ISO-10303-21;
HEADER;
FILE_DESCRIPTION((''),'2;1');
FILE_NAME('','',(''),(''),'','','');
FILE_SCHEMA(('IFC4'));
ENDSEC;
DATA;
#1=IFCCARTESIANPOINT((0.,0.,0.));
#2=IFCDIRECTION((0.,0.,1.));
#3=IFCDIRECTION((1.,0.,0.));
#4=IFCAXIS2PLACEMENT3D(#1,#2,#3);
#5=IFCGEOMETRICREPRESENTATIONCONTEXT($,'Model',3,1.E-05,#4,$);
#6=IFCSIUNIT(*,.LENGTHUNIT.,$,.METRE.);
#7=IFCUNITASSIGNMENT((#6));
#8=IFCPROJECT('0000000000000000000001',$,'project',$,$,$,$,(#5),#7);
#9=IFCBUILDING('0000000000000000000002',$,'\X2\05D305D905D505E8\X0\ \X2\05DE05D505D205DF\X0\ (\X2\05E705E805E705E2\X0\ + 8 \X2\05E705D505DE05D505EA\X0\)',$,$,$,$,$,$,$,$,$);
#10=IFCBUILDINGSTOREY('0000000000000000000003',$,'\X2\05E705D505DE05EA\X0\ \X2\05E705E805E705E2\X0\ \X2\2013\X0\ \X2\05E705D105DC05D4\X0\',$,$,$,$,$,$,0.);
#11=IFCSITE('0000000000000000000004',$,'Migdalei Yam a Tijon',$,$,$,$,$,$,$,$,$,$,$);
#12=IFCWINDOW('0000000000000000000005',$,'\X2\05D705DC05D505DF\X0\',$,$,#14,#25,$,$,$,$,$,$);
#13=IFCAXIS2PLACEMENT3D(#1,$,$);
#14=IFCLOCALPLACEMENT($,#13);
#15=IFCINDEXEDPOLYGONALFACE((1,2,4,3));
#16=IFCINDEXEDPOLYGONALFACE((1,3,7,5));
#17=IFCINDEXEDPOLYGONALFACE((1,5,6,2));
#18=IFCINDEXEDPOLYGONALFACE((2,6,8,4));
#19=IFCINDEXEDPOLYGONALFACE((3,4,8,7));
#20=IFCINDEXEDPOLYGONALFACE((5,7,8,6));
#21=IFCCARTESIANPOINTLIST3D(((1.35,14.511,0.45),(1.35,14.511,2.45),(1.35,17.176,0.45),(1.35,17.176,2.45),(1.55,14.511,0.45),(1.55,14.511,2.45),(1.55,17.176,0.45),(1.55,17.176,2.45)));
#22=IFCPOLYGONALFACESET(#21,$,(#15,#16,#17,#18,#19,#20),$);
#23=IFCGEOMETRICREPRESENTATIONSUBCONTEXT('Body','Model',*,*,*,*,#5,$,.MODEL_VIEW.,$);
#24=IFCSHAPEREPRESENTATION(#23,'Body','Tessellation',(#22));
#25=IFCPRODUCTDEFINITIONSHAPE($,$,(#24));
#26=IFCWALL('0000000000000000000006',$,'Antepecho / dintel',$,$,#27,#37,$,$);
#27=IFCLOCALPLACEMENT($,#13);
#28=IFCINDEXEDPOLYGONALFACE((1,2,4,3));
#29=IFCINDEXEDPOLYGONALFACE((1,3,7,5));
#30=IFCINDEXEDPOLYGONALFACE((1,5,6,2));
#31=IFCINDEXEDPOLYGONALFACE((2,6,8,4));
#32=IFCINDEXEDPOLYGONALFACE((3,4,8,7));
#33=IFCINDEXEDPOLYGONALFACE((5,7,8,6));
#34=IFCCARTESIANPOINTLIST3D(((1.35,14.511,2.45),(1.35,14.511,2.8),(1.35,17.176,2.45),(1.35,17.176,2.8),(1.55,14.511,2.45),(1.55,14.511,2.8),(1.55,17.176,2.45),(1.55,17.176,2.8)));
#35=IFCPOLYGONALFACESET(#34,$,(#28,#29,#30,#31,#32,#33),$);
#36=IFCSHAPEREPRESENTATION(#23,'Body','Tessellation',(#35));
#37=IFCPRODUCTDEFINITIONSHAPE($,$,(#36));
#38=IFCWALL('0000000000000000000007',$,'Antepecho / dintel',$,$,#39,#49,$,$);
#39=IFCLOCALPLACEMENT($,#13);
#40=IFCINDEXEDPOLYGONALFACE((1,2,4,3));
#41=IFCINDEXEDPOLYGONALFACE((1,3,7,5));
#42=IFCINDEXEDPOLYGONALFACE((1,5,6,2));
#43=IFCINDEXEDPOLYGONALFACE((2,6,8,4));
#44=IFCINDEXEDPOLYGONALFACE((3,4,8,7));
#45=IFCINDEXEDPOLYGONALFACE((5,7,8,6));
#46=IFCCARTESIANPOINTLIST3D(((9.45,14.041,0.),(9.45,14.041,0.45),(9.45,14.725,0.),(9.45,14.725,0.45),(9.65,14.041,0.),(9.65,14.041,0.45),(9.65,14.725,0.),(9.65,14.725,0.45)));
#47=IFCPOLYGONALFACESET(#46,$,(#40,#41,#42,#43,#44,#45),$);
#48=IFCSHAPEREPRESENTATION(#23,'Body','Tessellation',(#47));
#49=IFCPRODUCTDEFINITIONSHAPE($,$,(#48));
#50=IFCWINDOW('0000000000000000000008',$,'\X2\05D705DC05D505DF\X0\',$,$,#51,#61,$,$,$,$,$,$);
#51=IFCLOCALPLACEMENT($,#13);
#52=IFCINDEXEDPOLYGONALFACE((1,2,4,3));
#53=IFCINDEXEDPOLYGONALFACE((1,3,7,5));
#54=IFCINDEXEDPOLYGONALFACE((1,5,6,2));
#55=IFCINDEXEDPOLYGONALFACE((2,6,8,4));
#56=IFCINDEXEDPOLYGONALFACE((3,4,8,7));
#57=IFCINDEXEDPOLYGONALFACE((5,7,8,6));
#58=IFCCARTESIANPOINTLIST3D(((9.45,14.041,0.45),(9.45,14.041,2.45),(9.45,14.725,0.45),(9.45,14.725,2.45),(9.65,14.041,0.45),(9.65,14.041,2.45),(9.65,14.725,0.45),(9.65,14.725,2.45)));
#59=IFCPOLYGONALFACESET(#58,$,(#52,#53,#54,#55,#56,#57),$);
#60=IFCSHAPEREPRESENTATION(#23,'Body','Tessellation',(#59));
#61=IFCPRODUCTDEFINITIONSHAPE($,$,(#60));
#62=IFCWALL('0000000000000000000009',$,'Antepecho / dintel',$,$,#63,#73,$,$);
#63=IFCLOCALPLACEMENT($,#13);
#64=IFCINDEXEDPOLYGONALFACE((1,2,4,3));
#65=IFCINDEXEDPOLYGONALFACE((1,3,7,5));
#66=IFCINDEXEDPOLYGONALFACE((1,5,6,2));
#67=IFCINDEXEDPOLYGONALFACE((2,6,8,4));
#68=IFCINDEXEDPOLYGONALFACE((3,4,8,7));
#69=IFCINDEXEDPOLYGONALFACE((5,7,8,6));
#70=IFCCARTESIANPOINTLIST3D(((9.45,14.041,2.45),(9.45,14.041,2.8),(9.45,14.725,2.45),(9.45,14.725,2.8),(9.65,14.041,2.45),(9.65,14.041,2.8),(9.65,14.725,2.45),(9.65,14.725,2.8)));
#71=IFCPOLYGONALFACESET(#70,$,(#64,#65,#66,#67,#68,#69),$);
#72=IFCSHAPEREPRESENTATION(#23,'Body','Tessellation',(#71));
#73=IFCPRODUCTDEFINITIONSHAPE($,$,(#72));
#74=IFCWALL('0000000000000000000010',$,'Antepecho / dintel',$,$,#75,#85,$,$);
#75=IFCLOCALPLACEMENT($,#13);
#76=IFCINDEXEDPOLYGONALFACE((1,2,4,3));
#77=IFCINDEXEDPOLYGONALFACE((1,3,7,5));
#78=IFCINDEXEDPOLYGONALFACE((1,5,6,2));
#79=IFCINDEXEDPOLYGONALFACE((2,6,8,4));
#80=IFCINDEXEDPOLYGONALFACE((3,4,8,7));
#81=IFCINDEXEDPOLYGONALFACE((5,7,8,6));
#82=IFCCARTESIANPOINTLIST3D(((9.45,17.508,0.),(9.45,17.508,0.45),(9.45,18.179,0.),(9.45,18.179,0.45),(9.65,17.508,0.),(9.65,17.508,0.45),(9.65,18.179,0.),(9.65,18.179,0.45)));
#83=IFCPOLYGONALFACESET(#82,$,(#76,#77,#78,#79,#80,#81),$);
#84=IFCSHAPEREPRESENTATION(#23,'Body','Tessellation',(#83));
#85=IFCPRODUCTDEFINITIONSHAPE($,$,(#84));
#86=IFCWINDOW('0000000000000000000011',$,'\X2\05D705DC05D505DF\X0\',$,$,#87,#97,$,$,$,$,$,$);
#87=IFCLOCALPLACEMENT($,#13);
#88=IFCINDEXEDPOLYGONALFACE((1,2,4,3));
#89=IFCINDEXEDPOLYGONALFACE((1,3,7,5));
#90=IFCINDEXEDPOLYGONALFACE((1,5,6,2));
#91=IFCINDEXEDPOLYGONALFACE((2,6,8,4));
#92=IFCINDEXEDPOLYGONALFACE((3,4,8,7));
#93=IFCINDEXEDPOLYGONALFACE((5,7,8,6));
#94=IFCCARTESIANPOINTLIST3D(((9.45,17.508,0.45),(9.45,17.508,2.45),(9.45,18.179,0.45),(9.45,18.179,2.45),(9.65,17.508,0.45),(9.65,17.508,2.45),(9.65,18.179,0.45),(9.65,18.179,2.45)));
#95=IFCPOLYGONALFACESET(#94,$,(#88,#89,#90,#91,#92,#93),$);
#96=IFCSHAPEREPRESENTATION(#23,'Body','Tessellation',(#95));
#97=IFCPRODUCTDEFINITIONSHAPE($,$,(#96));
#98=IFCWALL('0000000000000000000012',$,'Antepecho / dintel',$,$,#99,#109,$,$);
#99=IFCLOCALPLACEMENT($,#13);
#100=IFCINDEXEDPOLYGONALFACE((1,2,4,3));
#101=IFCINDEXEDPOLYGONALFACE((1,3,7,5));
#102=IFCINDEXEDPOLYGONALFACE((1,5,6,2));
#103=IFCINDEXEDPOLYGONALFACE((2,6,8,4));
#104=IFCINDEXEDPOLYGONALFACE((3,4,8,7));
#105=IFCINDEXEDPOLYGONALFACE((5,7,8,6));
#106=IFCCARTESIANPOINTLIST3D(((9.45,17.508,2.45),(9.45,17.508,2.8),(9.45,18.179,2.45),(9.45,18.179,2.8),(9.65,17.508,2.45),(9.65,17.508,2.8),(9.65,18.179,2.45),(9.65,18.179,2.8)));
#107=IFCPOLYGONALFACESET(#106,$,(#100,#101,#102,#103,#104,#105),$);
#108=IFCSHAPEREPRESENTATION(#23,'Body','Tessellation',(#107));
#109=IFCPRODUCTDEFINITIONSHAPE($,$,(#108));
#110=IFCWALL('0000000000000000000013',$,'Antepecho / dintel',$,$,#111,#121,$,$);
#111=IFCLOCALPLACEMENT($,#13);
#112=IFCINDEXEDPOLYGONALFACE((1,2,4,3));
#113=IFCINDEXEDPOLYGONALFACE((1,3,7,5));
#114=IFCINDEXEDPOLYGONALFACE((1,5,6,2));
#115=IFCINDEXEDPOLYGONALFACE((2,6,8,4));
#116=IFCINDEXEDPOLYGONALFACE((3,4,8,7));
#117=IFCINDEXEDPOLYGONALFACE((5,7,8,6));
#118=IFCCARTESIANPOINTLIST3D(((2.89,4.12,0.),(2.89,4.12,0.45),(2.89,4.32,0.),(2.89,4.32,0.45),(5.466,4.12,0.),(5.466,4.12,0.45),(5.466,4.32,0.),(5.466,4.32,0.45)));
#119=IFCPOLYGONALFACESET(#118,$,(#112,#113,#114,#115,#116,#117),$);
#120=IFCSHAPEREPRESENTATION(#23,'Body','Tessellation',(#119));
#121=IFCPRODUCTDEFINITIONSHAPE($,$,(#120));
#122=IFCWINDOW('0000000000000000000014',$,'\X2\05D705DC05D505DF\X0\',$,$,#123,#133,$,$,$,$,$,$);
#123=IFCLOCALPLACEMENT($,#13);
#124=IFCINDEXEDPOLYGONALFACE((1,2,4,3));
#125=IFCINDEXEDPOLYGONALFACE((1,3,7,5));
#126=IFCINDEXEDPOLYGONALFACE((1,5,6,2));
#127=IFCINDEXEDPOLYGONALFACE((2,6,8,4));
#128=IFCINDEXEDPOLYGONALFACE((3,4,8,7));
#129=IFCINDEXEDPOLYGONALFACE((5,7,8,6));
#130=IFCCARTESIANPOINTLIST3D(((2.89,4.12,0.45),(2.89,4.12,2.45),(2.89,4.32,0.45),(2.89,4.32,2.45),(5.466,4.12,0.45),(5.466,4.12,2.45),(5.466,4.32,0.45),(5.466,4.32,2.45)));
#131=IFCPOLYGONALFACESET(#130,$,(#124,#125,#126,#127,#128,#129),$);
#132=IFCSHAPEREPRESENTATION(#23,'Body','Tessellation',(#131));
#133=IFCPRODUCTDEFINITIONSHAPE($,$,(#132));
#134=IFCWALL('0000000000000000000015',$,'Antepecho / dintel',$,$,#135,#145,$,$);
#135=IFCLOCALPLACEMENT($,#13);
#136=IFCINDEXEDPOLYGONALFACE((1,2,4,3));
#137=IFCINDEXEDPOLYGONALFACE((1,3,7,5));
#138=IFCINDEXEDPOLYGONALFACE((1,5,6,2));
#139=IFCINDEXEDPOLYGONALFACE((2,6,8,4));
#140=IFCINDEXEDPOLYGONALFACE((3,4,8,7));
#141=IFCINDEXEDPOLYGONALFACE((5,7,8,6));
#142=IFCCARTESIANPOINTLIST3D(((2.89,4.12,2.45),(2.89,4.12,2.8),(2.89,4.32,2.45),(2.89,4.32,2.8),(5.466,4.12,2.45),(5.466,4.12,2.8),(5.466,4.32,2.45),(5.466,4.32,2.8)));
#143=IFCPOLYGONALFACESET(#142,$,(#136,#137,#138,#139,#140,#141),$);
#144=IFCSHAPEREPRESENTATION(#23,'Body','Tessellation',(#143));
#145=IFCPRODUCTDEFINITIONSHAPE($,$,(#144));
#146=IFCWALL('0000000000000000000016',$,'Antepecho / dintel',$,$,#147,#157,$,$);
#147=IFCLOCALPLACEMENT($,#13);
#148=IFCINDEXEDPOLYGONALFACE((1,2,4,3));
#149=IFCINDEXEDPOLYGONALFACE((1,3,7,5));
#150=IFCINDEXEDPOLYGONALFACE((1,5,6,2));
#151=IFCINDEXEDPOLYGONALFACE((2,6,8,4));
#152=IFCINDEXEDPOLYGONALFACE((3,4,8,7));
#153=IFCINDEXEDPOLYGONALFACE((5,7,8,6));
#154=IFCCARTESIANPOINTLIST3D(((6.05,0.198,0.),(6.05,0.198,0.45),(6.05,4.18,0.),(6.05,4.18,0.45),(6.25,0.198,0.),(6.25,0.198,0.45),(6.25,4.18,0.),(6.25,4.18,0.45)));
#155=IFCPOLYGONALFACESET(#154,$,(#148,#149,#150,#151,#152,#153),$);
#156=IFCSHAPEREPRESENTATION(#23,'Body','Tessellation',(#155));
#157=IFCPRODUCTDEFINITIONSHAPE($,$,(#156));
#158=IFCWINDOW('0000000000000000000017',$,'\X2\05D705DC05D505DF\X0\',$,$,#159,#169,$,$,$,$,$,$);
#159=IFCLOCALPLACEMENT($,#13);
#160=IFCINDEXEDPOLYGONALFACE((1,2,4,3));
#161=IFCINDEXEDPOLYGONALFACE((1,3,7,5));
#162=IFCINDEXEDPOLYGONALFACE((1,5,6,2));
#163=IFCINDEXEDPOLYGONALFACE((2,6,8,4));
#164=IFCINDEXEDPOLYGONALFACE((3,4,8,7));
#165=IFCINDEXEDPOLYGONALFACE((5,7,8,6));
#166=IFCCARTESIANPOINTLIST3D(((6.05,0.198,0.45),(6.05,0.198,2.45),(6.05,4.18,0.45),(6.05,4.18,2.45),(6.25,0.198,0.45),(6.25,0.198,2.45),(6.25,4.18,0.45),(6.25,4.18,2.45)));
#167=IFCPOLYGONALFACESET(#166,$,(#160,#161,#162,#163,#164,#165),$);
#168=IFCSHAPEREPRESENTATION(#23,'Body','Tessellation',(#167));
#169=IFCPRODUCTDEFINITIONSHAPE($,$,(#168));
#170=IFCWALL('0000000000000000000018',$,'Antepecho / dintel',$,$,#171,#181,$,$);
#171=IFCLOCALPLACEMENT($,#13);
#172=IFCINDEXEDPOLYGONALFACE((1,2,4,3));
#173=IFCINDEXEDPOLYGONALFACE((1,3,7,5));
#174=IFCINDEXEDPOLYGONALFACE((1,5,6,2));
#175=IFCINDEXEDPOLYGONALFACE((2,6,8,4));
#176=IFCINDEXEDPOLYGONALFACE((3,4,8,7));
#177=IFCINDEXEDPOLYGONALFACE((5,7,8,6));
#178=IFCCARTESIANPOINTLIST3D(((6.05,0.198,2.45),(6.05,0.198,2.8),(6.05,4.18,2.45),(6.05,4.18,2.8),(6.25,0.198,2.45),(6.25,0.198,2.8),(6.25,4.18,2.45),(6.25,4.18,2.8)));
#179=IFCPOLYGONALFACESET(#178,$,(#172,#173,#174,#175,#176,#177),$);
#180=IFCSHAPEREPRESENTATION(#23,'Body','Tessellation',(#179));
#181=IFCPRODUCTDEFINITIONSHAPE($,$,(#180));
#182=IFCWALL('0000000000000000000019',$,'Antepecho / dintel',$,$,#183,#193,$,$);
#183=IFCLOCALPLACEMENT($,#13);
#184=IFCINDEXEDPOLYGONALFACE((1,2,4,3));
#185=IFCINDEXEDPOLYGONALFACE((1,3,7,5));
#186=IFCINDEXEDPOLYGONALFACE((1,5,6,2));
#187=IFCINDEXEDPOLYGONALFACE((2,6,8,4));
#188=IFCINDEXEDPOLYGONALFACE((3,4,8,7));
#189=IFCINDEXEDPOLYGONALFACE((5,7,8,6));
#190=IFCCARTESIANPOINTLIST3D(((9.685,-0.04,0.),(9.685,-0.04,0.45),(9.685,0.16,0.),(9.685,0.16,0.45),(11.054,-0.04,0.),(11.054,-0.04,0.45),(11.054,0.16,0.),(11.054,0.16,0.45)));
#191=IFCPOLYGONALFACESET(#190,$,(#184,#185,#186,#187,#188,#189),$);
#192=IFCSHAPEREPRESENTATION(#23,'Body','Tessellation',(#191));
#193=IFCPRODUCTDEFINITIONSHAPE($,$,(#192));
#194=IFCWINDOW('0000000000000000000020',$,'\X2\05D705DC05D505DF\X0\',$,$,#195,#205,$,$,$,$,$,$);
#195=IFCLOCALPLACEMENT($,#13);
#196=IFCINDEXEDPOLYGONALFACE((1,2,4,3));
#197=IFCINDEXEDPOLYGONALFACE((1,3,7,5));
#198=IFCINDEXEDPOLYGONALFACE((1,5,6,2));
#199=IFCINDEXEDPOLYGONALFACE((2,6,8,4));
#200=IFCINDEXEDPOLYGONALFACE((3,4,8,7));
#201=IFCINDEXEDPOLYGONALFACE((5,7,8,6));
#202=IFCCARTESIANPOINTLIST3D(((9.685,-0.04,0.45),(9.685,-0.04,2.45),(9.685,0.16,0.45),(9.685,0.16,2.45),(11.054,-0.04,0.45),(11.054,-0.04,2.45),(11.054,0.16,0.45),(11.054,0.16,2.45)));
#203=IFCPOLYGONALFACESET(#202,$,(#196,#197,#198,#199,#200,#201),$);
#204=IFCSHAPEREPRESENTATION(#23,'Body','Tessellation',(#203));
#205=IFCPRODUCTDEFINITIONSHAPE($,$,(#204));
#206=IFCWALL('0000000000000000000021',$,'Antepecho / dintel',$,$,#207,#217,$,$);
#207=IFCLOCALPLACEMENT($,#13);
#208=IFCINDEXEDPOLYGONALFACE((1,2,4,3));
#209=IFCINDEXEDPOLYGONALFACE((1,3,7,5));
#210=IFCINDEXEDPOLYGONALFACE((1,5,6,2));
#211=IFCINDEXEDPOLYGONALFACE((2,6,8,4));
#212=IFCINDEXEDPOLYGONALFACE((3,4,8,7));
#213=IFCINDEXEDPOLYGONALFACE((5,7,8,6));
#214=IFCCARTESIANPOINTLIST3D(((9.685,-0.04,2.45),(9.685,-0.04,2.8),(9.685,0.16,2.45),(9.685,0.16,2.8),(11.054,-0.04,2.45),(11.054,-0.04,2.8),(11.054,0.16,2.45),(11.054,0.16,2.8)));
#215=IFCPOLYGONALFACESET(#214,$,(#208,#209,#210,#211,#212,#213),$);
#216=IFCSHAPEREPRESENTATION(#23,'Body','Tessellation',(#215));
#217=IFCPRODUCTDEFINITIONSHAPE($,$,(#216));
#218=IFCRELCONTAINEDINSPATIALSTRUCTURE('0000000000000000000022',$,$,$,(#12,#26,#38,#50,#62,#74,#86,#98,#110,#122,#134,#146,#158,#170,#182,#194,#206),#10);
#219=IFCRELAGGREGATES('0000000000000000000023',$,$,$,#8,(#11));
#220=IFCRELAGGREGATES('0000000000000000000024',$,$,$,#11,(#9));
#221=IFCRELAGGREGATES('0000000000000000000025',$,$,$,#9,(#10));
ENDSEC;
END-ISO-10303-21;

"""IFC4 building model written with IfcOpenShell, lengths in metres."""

from ifc_helpers import new_model, si_unit, frame, origin_with_axes, context, subcontext, project, spatial, line, indexed_curve, outline, extrude, element, save


model = new_model("IFC4")

# Units and contexts
model_context = context("Model", 3, precision=1e-05, world=origin_with_axes())
body_context = subcontext(model_context, "Body", "Model", "MODEL_VIEW")
ifc_project = project(units=[si_unit("LENGTHUNIT", "METRE")], contexts=[model_context])

# Site, building, storey
site = spatial("IfcSite", under=ifc_project, Name="Migdalei Yam a Tijon")
building = spatial("IfcBuilding", under=site, Name="דיור מוגן (קרקע + 8 קומות)")
storey = spatial("IfcBuildingStorey", under=building, Name="קומת קרקע – קבלה", Elevation=0.0)

# Window
element("IfcWindow", 1, inside=storey, Name="חלון", context=body_context, shape_type="SweptSolid", body=[
    extrude(outline(indexed_curve([(0.0, 0.0), (0.2, 0.0), (0.2, 2.665), (0.0, 2.665)], segments=[line(1, 2, 3, 4, 1)])), frame((1.35, 14.511, 0.45), z_axis=(0.0, 0.0, 1.0), x_axis=(1.0, 0.0, 0.0)), (0.0, 0.0, 1.0), 2.0),
])

# Walls
element("IfcWall", 2, inside=storey, Name="Antepecho / dintel", context=body_context, shape_type="SweptSolid", body=[
    extrude(outline(indexed_curve([(0.0, 0.0), (0.2, 0.0), (0.2, 2.665), (0.0, 2.665)], segments=[line(1, 2, 3, 4, 1)])), frame((1.35, 14.511, 2.45), z_axis=(0.0, 0.0, 1.0), x_axis=(1.0, 0.0, 0.0)), (0.0, 0.0, 1.0), 0.35),
])
element("IfcWall", 3, inside=storey, Name="Antepecho / dintel", context=body_context, shape_type="SweptSolid", body=[
    extrude(outline(indexed_curve([(0.0, 0.0), (0.2, 0.0), (0.2, 0.684), (0.0, 0.684)], segments=[line(1, 2, 3, 4, 1)])), frame((9.45, 14.041, 0.0), z_axis=(0.0, 0.0, 1.0), x_axis=(1.0, 0.0, 0.0)), (0.0, 0.0, 1.0), 0.45),
])

# Window
element("IfcWindow", 4, inside=storey, Name="חלון", context=body_context, shape_type="SweptSolid", body=[
    extrude(outline(indexed_curve([(0.0, 0.0), (0.2, 0.0), (0.2, 0.684), (0.0, 0.684)], segments=[line(1, 2, 3, 4, 1)])), frame((9.45, 14.041, 0.45), z_axis=(0.0, 0.0, 1.0), x_axis=(1.0, 0.0, 0.0)), (0.0, 0.0, 1.0), 2.0),
])

# Walls
element("IfcWall", 5, inside=storey, Name="Antepecho / dintel", context=body_context, shape_type="SweptSolid", body=[
    extrude(outline(indexed_curve([(0.0, 0.0), (0.2, 0.0), (0.2, 0.684), (0.0, 0.684)], segments=[line(1, 2, 3, 4, 1)])), frame((9.45, 14.041, 2.45), z_axis=(0.0, 0.0, 1.0), x_axis=(1.0, 0.0, 0.0)), (0.0, 0.0, 1.0), 0.35),
])
element("IfcWall", 6, inside=storey, Name="Antepecho / dintel", context=body_context, shape_type="SweptSolid", body=[
    extrude(outline(indexed_curve([(0.0, 0.0), (0.2, 0.0), (0.2, 0.671), (0.0, 0.671)], segments=[line(1, 2, 3, 4, 1)])), frame((9.45, 17.508, 0.0), z_axis=(0.0, 0.0, 1.0), x_axis=(1.0, 0.0, 0.0)), (0.0, 0.0, 1.0), 0.45),
])

# Window
element("IfcWindow", 7, inside=storey, Name="חלון", context=body_context, shape_type="SweptSolid", body=[
    extrude(outline(indexed_curve([(0.0, 0.0), (0.2, 0.0), (0.2, 0.671), (0.0, 0.671)], segments=[line(1, 2, 3, 4, 1)])), frame((9.45, 17.508, 0.45), z_axis=(0.0, 0.0, 1.0), x_axis=(1.0, 0.0, 0.0)), (0.0, 0.0, 1.0), 2.0),
])

# Walls
element("IfcWall", 8, inside=storey, Name="Antepecho / dintel", context=body_context, shape_type="SweptSolid", body=[
    extrude(outline(indexed_curve([(0.0, 0.0), (0.2, 0.0), (0.2, 0.671), (0.0, 0.671)], segments=[line(1, 2, 3, 4, 1)])), frame((9.45, 17.508, 2.45), z_axis=(0.0, 0.0, 1.0), x_axis=(1.0, 0.0, 0.0)), (0.0, 0.0, 1.0), 0.35),
])
element("IfcWall", 9, inside=storey, Name="Antepecho / dintel", context=body_context, shape_type="SweptSolid", body=[
    extrude(outline(indexed_curve([(0.0, 0.0), (2.576, 0.0), (2.576, 0.2), (0.0, 0.2)], segments=[line(1, 2, 3, 4, 1)])), frame((2.89, 4.12, 0.0), z_axis=(0.0, 0.0, 1.0), x_axis=(1.0, 0.0, 0.0)), (0.0, 0.0, 1.0), 0.45),
])

# Window
element("IfcWindow", 10, inside=storey, Name="חלון", context=body_context, shape_type="SweptSolid", body=[
    extrude(outline(indexed_curve([(0.0, 0.0), (2.576, 0.0), (2.576, 0.2), (0.0, 0.2)], segments=[line(1, 2, 3, 4, 1)])), frame((2.89, 4.12, 0.45), z_axis=(0.0, 0.0, 1.0), x_axis=(1.0, 0.0, 0.0)), (0.0, 0.0, 1.0), 2.0),
])

# Walls
element("IfcWall", 11, inside=storey, Name="Antepecho / dintel", context=body_context, shape_type="SweptSolid", body=[
    extrude(outline(indexed_curve([(0.0, 0.0), (2.576, 0.0), (2.576, 0.2), (0.0, 0.2)], segments=[line(1, 2, 3, 4, 1)])), frame((2.89, 4.12, 2.45), z_axis=(0.0, 0.0, 1.0), x_axis=(1.0, 0.0, 0.0)), (0.0, 0.0, 1.0), 0.35),
])
element("IfcWall", 12, inside=storey, Name="Antepecho / dintel", context=body_context, shape_type="SweptSolid", body=[
    extrude(outline(indexed_curve([(0.0, 0.0), (0.2, 0.0), (0.2, 3.982), (0.0, 3.982)], segments=[line(1, 2, 3, 4, 1)])), frame((6.05, 0.198, 0.0), z_axis=(0.0, 0.0, 1.0), x_axis=(1.0, 0.0, 0.0)), (0.0, 0.0, 1.0), 0.45),
])

# Window
element("IfcWindow", 13, inside=storey, Name="חלון", context=body_context, shape_type="SweptSolid", body=[
    extrude(outline(indexed_curve([(0.0, 0.0), (0.2, 0.0), (0.2, 3.982), (0.0, 3.982)], segments=[line(1, 2, 3, 4, 1)])), frame((6.05, 0.198, 0.45), z_axis=(0.0, 0.0, 1.0), x_axis=(1.0, 0.0, 0.0)), (0.0, 0.0, 1.0), 2.0),
])

# Walls
element("IfcWall", 14, inside=storey, Name="Antepecho / dintel", context=body_context, shape_type="SweptSolid", body=[
    extrude(outline(indexed_curve([(0.0, 0.0), (0.2, 0.0), (0.2, 3.982), (0.0, 3.982)], segments=[line(1, 2, 3, 4, 1)])), frame((6.05, 0.198, 2.45), z_axis=(0.0, 0.0, 1.0), x_axis=(1.0, 0.0, 0.0)), (0.0, 0.0, 1.0), 0.35),
])
element("IfcWall", 15, inside=storey, Name="Antepecho / dintel", context=body_context, shape_type="SweptSolid", body=[
    extrude(outline(indexed_curve([(0.0, 0.0), (1.369, 0.0), (1.369, 0.2), (0.0, 0.2)], segments=[line(1, 2, 3, 4, 1)])), frame((9.685, -0.04, 0.0), z_axis=(0.0, 0.0, 1.0), x_axis=(1.0, 0.0, 0.0)), (0.0, 0.0, 1.0), 0.45),
])

# Window
element("IfcWindow", 16, inside=storey, Name="חלון", context=body_context, shape_type="SweptSolid", body=[
    extrude(outline(indexed_curve([(0.0, 0.0), (1.369, 0.0), (1.369, 0.2), (0.0, 0.2)], segments=[line(1, 2, 3, 4, 1)])), frame((9.685, -0.04, 0.45), z_axis=(0.0, 0.0, 1.0), x_axis=(1.0, 0.0, 0.0)), (0.0, 0.0, 1.0), 2.0),
])

# Wall
element("IfcWall", 17, inside=storey, Name="Antepecho / dintel", context=body_context, shape_type="SweptSolid", body=[
    extrude(outline(indexed_curve([(0.0, 0.0), (1.369, 0.0), (1.369, 0.2), (0.0, 0.2)], segments=[line(1, 2, 3, 4, 1)])), frame((9.685, -0.04, 2.45), z_axis=(0.0, 0.0, 1.0), x_axis=(1.0, 0.0, 0.0)), (0.0, 0.0, 1.0), 0.35),
])

save(model, "model.ifc")
